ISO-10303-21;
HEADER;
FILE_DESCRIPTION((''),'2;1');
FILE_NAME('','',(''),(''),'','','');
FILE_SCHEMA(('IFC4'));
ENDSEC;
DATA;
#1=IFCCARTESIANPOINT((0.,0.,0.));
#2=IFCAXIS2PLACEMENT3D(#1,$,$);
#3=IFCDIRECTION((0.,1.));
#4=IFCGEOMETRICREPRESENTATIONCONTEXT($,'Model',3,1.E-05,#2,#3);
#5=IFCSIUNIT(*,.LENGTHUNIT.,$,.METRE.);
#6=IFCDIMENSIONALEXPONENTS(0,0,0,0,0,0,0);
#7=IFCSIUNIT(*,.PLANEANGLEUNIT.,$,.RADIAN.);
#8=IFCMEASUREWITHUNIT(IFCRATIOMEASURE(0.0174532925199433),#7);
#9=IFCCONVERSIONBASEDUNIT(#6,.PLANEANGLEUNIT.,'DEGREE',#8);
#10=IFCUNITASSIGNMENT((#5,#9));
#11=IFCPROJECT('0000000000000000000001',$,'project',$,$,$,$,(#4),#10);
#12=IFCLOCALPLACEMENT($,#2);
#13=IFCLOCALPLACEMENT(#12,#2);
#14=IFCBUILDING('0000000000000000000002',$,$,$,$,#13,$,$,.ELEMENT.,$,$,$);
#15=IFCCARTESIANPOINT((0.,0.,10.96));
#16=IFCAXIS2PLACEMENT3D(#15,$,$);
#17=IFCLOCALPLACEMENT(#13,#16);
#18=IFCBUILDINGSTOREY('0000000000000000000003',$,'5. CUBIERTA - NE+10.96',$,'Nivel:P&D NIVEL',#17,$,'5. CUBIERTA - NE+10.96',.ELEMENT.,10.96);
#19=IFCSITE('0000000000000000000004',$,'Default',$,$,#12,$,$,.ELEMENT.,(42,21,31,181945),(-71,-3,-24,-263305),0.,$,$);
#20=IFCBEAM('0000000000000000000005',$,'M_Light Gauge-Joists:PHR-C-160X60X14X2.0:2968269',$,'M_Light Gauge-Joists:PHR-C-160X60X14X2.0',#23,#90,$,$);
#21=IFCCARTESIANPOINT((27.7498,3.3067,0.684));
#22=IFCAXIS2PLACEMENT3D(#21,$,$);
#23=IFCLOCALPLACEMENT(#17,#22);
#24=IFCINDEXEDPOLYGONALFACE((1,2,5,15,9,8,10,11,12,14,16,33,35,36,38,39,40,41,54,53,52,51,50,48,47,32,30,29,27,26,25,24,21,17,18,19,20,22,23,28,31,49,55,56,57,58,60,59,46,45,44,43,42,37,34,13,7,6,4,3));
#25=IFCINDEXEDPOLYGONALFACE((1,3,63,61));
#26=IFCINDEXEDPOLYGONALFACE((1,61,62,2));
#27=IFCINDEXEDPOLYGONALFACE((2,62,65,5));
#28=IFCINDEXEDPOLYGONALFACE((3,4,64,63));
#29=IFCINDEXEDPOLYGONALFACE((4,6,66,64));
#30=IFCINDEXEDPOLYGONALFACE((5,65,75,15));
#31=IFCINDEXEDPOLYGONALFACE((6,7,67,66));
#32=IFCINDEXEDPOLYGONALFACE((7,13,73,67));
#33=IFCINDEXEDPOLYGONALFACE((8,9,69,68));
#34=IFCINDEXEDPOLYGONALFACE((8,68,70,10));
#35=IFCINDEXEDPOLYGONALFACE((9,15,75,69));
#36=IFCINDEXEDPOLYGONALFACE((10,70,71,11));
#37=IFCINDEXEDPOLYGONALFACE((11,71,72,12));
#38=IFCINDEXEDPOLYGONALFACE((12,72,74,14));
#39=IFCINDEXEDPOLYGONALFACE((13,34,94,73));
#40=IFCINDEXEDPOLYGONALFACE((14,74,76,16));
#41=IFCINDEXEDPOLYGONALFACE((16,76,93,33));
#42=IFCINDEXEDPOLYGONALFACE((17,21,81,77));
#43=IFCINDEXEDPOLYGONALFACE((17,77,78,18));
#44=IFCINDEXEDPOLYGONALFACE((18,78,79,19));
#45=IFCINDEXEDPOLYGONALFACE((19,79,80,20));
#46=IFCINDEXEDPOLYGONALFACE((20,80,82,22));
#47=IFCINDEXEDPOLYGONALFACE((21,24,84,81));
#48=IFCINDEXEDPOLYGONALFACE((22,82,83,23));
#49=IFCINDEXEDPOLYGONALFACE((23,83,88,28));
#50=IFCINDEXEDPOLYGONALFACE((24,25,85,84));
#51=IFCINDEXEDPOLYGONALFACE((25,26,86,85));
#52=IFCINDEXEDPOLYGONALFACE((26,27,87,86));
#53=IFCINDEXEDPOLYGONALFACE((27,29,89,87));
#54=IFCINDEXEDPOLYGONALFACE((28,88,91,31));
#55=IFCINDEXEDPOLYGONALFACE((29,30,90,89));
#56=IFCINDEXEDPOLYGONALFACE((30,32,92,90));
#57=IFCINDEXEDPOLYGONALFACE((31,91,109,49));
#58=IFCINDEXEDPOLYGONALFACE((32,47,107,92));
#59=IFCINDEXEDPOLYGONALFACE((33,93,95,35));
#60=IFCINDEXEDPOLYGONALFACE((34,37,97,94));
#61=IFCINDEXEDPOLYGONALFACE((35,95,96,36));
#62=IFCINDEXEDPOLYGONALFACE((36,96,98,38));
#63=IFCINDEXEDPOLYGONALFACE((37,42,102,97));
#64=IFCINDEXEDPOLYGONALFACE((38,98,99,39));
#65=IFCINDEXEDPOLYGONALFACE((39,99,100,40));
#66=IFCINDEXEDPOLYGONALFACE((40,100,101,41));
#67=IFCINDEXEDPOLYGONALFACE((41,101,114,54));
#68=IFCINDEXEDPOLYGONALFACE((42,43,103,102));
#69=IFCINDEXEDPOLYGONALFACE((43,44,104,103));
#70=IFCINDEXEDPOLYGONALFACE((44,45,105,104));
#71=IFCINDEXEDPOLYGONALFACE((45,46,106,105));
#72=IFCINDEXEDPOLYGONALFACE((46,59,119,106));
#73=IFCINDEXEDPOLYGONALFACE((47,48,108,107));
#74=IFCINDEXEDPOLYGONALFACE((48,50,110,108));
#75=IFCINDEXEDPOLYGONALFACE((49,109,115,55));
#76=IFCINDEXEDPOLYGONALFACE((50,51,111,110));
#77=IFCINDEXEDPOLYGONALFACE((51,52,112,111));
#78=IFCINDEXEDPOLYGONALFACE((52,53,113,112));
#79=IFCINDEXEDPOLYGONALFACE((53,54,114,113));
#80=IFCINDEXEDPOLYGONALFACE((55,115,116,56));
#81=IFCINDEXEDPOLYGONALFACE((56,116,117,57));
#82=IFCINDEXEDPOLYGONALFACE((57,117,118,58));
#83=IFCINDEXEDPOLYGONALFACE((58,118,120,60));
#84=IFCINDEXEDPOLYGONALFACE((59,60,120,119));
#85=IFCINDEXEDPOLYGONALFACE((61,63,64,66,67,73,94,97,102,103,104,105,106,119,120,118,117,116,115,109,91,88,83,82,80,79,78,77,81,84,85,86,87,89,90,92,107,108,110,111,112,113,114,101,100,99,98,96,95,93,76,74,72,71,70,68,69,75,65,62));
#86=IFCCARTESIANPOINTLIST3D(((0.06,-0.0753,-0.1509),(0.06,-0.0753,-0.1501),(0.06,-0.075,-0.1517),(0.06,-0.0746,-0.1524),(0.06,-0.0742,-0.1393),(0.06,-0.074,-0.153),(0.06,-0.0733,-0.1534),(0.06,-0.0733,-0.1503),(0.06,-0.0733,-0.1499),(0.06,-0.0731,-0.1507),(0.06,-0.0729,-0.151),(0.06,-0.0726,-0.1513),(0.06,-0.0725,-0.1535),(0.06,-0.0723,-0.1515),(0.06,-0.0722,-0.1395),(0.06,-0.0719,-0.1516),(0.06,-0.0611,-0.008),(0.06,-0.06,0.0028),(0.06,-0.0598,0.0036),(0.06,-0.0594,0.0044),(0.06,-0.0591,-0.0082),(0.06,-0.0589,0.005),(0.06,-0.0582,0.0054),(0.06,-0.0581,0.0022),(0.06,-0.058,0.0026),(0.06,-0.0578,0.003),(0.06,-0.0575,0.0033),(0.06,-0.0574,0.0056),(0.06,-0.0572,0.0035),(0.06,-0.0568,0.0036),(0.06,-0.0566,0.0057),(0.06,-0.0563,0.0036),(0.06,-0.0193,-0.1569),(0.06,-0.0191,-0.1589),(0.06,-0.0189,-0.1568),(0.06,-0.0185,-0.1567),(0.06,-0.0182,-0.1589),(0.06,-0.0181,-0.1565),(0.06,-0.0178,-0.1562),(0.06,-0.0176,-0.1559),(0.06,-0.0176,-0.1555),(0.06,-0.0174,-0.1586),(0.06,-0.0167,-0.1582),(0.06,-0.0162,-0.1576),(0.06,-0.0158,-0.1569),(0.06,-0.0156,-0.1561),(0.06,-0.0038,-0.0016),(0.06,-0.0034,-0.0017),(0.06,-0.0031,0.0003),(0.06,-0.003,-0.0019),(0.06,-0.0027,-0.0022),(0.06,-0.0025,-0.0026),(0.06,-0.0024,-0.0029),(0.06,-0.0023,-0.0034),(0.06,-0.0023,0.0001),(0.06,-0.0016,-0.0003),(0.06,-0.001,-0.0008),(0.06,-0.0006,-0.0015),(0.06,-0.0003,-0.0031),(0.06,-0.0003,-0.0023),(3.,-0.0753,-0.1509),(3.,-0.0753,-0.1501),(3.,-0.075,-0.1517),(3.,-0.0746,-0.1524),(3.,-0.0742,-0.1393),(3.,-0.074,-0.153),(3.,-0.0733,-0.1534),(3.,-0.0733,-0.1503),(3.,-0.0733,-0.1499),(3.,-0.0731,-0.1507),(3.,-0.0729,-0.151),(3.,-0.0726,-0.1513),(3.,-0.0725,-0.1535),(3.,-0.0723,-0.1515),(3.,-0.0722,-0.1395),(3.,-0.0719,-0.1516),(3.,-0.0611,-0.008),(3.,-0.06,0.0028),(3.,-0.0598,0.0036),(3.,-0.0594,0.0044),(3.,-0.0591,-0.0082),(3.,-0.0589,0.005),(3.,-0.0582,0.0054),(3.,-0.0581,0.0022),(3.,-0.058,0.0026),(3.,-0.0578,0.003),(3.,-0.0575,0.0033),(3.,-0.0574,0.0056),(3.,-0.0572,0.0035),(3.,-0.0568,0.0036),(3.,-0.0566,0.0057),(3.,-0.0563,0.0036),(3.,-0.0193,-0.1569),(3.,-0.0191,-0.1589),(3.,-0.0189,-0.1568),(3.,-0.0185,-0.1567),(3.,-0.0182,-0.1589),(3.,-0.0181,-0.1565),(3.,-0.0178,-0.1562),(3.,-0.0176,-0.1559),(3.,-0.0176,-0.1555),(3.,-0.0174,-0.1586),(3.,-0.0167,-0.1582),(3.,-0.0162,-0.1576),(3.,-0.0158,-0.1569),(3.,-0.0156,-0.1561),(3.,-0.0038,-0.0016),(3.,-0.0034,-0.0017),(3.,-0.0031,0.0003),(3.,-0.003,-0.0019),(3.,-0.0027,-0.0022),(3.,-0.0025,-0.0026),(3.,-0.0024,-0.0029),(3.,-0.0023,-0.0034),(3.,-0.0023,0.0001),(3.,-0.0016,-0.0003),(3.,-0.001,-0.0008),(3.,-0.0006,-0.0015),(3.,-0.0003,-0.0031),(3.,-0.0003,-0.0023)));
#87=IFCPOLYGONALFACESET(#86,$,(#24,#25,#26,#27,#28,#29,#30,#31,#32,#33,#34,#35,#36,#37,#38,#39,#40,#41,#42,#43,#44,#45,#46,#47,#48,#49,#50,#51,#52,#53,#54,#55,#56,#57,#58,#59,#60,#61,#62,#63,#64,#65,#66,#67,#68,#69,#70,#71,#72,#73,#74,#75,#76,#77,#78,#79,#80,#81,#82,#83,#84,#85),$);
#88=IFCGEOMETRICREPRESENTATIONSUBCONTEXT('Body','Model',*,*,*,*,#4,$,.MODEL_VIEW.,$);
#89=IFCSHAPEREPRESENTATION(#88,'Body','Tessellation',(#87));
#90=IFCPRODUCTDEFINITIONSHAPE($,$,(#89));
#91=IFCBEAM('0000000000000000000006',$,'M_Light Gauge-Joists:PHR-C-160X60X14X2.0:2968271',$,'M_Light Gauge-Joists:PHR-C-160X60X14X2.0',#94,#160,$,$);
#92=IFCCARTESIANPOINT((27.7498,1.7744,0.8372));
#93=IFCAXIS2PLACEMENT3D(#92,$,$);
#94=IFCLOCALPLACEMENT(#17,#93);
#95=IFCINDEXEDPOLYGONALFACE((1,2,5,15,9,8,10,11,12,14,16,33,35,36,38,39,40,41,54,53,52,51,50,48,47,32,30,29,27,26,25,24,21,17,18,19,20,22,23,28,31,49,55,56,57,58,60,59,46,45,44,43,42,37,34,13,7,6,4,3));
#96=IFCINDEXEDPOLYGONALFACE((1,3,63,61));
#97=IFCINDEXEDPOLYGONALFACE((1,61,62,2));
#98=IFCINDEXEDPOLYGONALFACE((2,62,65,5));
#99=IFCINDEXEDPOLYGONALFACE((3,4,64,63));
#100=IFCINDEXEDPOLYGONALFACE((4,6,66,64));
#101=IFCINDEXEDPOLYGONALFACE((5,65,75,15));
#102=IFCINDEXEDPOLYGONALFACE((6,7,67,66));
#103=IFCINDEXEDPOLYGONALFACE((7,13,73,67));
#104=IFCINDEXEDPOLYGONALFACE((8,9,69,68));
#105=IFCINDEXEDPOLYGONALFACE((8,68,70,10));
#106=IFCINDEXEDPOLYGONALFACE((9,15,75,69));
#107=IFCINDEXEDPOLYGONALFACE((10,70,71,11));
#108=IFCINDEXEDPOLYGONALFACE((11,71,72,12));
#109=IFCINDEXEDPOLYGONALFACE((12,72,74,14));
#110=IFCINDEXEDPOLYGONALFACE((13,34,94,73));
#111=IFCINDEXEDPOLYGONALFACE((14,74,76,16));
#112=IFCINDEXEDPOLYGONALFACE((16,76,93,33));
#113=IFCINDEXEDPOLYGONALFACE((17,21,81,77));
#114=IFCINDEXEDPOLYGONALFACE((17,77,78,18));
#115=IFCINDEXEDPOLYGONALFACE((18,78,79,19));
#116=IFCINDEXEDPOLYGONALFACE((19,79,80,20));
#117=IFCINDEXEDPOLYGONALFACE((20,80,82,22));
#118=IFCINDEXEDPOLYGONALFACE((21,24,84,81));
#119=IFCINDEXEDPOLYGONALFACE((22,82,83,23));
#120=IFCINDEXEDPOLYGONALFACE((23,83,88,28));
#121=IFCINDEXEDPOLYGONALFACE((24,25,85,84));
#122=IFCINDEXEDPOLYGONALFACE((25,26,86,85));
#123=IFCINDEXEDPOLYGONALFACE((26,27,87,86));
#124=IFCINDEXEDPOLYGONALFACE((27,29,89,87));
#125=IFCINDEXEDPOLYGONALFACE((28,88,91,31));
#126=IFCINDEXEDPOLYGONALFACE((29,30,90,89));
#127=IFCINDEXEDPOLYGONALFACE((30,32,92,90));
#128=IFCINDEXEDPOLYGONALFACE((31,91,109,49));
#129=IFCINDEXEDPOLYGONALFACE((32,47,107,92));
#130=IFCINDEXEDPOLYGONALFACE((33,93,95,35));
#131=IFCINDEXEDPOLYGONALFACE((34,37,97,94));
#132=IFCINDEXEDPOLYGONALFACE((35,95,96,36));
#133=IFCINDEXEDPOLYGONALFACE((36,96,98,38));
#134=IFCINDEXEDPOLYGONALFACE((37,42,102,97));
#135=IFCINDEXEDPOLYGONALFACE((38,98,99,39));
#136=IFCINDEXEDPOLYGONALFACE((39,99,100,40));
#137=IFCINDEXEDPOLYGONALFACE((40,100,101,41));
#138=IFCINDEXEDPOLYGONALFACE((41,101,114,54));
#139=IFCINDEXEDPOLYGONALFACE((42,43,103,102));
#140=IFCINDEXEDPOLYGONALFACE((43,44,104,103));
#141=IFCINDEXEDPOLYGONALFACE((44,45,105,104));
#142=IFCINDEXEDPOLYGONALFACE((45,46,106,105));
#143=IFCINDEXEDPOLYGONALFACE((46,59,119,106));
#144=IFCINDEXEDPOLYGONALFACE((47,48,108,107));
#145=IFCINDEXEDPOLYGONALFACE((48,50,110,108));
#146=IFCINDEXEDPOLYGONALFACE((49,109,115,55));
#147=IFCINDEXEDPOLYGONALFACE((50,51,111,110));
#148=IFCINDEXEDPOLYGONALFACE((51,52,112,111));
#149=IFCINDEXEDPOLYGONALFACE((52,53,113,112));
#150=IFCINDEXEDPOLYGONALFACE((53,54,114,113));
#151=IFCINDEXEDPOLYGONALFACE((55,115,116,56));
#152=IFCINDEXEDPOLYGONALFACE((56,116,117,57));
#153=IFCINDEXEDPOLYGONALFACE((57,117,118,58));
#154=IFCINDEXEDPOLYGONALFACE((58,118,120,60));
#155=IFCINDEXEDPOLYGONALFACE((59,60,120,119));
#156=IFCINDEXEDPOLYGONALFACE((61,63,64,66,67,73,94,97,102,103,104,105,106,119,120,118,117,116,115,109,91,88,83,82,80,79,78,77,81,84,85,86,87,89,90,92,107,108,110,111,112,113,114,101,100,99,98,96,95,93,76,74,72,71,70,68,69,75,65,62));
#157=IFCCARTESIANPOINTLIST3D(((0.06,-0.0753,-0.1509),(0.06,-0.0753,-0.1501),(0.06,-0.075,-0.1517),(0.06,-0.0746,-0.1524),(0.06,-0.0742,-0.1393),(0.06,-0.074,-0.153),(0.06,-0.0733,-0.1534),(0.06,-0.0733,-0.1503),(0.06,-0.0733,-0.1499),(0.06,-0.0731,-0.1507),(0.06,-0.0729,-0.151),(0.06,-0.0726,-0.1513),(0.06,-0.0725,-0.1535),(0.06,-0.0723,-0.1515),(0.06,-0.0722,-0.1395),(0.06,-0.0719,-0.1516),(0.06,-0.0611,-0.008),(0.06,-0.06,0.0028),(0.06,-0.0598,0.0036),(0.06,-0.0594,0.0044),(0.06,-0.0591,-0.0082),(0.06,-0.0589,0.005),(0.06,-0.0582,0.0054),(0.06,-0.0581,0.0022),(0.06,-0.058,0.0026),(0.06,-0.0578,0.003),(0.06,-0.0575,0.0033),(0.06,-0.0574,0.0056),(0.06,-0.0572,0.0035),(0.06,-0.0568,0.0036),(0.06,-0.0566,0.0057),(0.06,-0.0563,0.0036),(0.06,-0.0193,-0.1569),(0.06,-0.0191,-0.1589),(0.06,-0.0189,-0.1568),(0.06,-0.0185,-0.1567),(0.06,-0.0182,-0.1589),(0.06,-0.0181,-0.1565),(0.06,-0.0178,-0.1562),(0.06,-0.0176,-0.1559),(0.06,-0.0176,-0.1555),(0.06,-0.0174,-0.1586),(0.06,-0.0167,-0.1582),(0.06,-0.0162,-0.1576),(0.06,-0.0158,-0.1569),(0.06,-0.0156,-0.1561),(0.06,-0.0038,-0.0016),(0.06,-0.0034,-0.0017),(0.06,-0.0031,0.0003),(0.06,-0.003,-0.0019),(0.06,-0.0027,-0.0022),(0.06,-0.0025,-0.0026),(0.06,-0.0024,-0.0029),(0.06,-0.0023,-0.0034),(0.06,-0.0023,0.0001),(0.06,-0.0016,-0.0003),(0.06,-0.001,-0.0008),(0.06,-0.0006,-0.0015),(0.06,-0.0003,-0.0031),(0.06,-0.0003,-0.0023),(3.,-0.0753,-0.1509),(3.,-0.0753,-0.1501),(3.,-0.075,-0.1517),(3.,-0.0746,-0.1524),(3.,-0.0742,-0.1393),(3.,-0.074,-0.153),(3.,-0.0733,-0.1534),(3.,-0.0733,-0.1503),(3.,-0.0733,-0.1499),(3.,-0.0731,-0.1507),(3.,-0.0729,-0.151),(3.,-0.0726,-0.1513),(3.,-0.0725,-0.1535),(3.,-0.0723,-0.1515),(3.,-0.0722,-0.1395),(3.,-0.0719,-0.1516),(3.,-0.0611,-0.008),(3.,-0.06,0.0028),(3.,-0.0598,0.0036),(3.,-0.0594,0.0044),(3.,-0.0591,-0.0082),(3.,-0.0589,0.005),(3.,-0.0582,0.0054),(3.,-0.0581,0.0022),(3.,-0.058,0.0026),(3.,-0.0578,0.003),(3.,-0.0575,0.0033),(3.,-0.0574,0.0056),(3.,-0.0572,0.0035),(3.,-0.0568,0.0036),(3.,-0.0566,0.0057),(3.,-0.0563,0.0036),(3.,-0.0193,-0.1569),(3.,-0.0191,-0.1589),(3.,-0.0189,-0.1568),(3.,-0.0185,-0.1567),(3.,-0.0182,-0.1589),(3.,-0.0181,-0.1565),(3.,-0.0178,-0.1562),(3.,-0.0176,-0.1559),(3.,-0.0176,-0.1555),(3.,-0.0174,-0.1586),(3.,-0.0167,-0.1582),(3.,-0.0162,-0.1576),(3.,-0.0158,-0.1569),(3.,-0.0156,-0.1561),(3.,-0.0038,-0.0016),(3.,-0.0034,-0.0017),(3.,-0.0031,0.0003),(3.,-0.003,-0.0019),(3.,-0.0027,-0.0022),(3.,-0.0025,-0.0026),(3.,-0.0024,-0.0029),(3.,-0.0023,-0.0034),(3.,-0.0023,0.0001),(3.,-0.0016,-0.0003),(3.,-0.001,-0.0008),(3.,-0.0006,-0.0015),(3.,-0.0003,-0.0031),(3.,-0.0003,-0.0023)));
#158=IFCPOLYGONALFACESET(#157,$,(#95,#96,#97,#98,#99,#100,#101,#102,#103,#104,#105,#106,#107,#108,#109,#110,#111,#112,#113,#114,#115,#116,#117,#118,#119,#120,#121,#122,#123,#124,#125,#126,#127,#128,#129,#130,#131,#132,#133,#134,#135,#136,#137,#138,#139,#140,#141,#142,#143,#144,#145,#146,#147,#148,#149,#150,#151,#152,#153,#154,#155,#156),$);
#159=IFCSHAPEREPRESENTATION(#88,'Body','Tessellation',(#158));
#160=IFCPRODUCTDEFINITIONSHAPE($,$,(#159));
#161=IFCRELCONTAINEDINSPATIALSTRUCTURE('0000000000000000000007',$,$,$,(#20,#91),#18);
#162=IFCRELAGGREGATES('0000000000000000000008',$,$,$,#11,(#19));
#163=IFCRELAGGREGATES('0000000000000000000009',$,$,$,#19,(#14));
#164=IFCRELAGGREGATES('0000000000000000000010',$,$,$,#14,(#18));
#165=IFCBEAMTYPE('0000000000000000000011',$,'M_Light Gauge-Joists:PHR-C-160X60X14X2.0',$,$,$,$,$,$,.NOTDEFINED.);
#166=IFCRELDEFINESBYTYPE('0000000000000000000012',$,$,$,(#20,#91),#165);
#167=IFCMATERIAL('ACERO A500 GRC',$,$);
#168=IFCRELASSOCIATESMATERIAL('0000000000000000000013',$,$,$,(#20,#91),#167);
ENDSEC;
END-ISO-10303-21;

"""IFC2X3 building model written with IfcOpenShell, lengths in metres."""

from ifc_helpers import new_model, entity, si_unit, converted_unit, direction, frame, frame_2d, origin, place, context, subcontext, project, spatial, polyline, circle_curve, parameter, trimmed, segment, composite_curve, outline, extrude, material, type_object, element, save


model = new_model("IFC2X3")

# Units and contexts
model_context = context("Model", 3, precision=1e-05, world=origin(), true_north=direction((0.0, 1.0)))
body_context = subcontext(model_context, "Body", "Model", "MODEL_VIEW")
ifc_project = project(units=[si_unit("LENGTHUNIT", "METRE"), converted_unit("PLANEANGLEUNIT", "DEGREE", entity("IfcRatioMeasure", 0.0174532925199433), si_unit("PLANEANGLEUNIT", "RADIAN"), dimensions=[0, 0, 0, 0, 0, 0, 0])], contexts=[model_context])

# Site, building, storey
site_placement = place(None, origin())
site = spatial("IfcSite", under=ifc_project, at=site_placement, Name="Default", CompositionType="ELEMENT", RefLatitude=(42, 21, 31, 181945), RefLongitude=(-71, -3, -24, -263305), RefElevation=0.0)
building_placement = place(site_placement, origin())
building = spatial("IfcBuilding", under=site, at=building_placement, CompositionType="ELEMENT")
storey_placement = place(building_placement, frame((0.0, 0.0, 10.96)))
storey = spatial("IfcBuildingStorey", under=building, at=storey_placement, Name="5. CUBIERTA - NE+10.96", ObjectType="Nivel:P&D NIVEL", LongName="5. CUBIERTA - NE+10.96", CompositionType="ELEMENT", Elevation=10.96)

# Beams
ifc_material_1 = material(Name="ACERO A500 GRC")
beam_type_1 = type_object("IfcBeamType", Name="M_Light Gauge-Joists:PHR-C-160X60X14X2.0", PredefinedType="NOTDEFINED")
beam_1_placement = place(storey_placement, frame((27.7498, 3.3067, 0.684)))
element("IfcBeam", 1, at=beam_1_placement, inside=storey, type_object=beam_type_1, material=ifc_material_1, Name="M_Light Gauge-Joists:PHR-C-160X60X14X2.0:2968269", ObjectType="M_Light Gauge-Joists:PHR-C-160X60X14X2.0", context=body_context, shape_type="SweptSolid", body=[
    extrude(outline(composite_curve([segment(polyline([(-0.0768, -0.0358), (0.0768, -0.0358)]), True, "CONTINUOUS"), segment(trimmed(circle_curve(frame_2d((0.0768, -0.0326), x_axis=(0.0, -1.0)), 0.0032), [parameter(0.0)], [parameter(90.0)], True, "PARAMETER"), True, "CONTINUOUS"), segment(polyline([(0.08, -0.0326), (0.08, 0.021)]), True, "CONTINUOUS"), segment(trimmed(circle_curve(frame_2d((0.0768, 0.021), x_axis=(1.0, 0.0)), 0.0032), [parameter(0.0)], [parameter(90.0)], True, "PARAMETER"), True, "CONTINUOUS"), segment(polyline([(0.0768, 0.0242), (0.066, 0.0242)]), True, "CONTINUOUS"), segment(polyline([(0.066, 0.0242), (0.066, 0.0222)]), True, "CONTINUOUS"), segment(polyline([(0.066, 0.0222), (0.0764, 0.0222)]), True, "CONTINUOUS"), segment(trimmed(circle_curve(frame_2d((0.0764, 0.0206), x_axis=(0.0, 1.0)), 0.0016), [parameter(270.0)], [parameter(0.0)], True, "PARAMETER"), False, "CONTINUOUS"), segment(polyline([(0.078, 0.0206), (0.078, -0.0322)]), True, "CONTINUOUS"), segment(trimmed(circle_curve(frame_2d((0.0764, -0.0322), x_axis=(1.0, 0.0)), 0.0016), [parameter(270.0)], [parameter(0.0)], True, "PARAMETER"), False, "CONTINUOUS"), segment(polyline([(0.0764, -0.0338), (-0.0764, -0.0338)]), True, "CONTINUOUS"), segment(trimmed(circle_curve(frame_2d((-0.0764, -0.0322), x_axis=(0.0, -1.0)), 0.0016), [parameter(270.0)], [parameter(0.0)], True, "PARAMETER"), False, "CONTINUOUS"), segment(polyline([(-0.078, -0.0322), (-0.078, 0.0206)]), True, "CONTINUOUS"), segment(trimmed(circle_curve(frame_2d((-0.0764, 0.0206), x_axis=(-1.0, 0.0)), 0.0016), [parameter(270.0)], [parameter(0.0)], True, "PARAMETER"), False, "CONTINUOUS"), segment(polyline([(-0.0764, 0.0222), (-0.066, 0.0222)]), True, "CONTINUOUS"), segment(polyline([(-0.066, 0.0222), (-0.066, 0.0242)]), True, "CONTINUOUS"), segment(polyline([(-0.066, 0.0242), (-0.0768, 0.0242)]), True, "CONTINUOUS"), segment(trimmed(circle_curve(frame_2d((-0.0768, 0.021), x_axis=(0.0, 1.0)), 0.0032), [parameter(0.0)], [parameter(90.0)], True, "PARAMETER"), True, "CONTINUOUS"), segment(polyline([(-0.08, 0.021), (-0.08, -0.0326)]), True, "CONTINUOUS"), segment(trimmed(circle_curve(frame_2d((-0.0768, -0.0326), x_axis=(-1.0, 0.0)), 0.0032), [parameter(0.0)], [parameter(90.0)], True, "PARAMETER"), True, "CONTINUOUS")], self_intersect=False)), frame((0.06, -0.0436, -0.076), z_axis=(1.0, 0.0, 0.0), x_axis=(0.0, 0.099504, 0.995037)), (0.0, 0.0, 1.0), 2.94),
])
beam_2_placement = place(storey_placement, frame((27.7498, 1.7744, 0.8372)))
element("IfcBeam", 2, at=beam_2_placement, inside=storey, type_object=beam_type_1, material=ifc_material_1, Name="M_Light Gauge-Joists:PHR-C-160X60X14X2.0:2968271", ObjectType="M_Light Gauge-Joists:PHR-C-160X60X14X2.0", context=body_context, shape_type="SweptSolid", body=[
    extrude(outline(composite_curve([segment(polyline([(-0.0768, -0.0358), (0.0768, -0.0358)]), True, "CONTINUOUS"), segment(trimmed(circle_curve(frame_2d((0.0768, -0.0326), x_axis=(0.0, -1.0)), 0.0032), [parameter(0.0)], [parameter(90.0)], True, "PARAMETER"), True, "CONTINUOUS"), segment(polyline([(0.08, -0.0326), (0.08, 0.021)]), True, "CONTINUOUS"), segment(trimmed(circle_curve(frame_2d((0.0768, 0.021), x_axis=(1.0, 0.0)), 0.0032), [parameter(0.0)], [parameter(90.0)], True, "PARAMETER"), True, "CONTINUOUS"), segment(polyline([(0.0768, 0.0242), (0.066, 0.0242)]), True, "CONTINUOUS"), segment(polyline([(0.066, 0.0242), (0.066, 0.0222)]), True, "CONTINUOUS"), segment(polyline([(0.066, 0.0222), (0.0764, 0.0222)]), True, "CONTINUOUS"), segment(trimmed(circle_curve(frame_2d((0.0764, 0.0206), x_axis=(0.0, 1.0)), 0.0016), [parameter(270.0)], [parameter(0.0)], True, "PARAMETER"), False, "CONTINUOUS"), segment(polyline([(0.078, 0.0206), (0.078, -0.0322)]), True, "CONTINUOUS"), segment(trimmed(circle_curve(frame_2d((0.0764, -0.0322), x_axis=(1.0, 0.0)), 0.0016), [parameter(270.0)], [parameter(0.0)], True, "PARAMETER"), False, "CONTINUOUS"), segment(polyline([(0.0764, -0.0338), (-0.0764, -0.0338)]), True, "CONTINUOUS"), segment(trimmed(circle_curve(frame_2d((-0.0764, -0.0322), x_axis=(0.0, -1.0)), 0.0016), [parameter(270.0)], [parameter(0.0)], True, "PARAMETER"), False, "CONTINUOUS"), segment(polyline([(-0.078, -0.0322), (-0.078, 0.0206)]), True, "CONTINUOUS"), segment(trimmed(circle_curve(frame_2d((-0.0764, 0.0206), x_axis=(-1.0, 0.0)), 0.0016), [parameter(270.0)], [parameter(0.0)], True, "PARAMETER"), False, "CONTINUOUS"), segment(polyline([(-0.0764, 0.0222), (-0.066, 0.0222)]), True, "CONTINUOUS"), segment(polyline([(-0.066, 0.0222), (-0.066, 0.0242)]), True, "CONTINUOUS"), segment(polyline([(-0.066, 0.0242), (-0.0768, 0.0242)]), True, "CONTINUOUS"), segment(trimmed(circle_curve(frame_2d((-0.0768, 0.021), x_axis=(0.0, 1.0)), 0.0032), [parameter(0.0)], [parameter(90.0)], True, "PARAMETER"), True, "CONTINUOUS"), segment(polyline([(-0.08, 0.021), (-0.08, -0.0326)]), True, "CONTINUOUS"), segment(trimmed(circle_curve(frame_2d((-0.0768, -0.0326), x_axis=(-1.0, 0.0)), 0.0032), [parameter(0.0)], [parameter(90.0)], True, "PARAMETER"), True, "CONTINUOUS")], self_intersect=False)), frame((0.06, -0.0436, -0.076), z_axis=(1.0, 0.0, 0.0), x_axis=(0.0, 0.099504, 0.995037)), (0.0, 0.0, 1.0), 2.94),
])

save(model, "model.ifc")
